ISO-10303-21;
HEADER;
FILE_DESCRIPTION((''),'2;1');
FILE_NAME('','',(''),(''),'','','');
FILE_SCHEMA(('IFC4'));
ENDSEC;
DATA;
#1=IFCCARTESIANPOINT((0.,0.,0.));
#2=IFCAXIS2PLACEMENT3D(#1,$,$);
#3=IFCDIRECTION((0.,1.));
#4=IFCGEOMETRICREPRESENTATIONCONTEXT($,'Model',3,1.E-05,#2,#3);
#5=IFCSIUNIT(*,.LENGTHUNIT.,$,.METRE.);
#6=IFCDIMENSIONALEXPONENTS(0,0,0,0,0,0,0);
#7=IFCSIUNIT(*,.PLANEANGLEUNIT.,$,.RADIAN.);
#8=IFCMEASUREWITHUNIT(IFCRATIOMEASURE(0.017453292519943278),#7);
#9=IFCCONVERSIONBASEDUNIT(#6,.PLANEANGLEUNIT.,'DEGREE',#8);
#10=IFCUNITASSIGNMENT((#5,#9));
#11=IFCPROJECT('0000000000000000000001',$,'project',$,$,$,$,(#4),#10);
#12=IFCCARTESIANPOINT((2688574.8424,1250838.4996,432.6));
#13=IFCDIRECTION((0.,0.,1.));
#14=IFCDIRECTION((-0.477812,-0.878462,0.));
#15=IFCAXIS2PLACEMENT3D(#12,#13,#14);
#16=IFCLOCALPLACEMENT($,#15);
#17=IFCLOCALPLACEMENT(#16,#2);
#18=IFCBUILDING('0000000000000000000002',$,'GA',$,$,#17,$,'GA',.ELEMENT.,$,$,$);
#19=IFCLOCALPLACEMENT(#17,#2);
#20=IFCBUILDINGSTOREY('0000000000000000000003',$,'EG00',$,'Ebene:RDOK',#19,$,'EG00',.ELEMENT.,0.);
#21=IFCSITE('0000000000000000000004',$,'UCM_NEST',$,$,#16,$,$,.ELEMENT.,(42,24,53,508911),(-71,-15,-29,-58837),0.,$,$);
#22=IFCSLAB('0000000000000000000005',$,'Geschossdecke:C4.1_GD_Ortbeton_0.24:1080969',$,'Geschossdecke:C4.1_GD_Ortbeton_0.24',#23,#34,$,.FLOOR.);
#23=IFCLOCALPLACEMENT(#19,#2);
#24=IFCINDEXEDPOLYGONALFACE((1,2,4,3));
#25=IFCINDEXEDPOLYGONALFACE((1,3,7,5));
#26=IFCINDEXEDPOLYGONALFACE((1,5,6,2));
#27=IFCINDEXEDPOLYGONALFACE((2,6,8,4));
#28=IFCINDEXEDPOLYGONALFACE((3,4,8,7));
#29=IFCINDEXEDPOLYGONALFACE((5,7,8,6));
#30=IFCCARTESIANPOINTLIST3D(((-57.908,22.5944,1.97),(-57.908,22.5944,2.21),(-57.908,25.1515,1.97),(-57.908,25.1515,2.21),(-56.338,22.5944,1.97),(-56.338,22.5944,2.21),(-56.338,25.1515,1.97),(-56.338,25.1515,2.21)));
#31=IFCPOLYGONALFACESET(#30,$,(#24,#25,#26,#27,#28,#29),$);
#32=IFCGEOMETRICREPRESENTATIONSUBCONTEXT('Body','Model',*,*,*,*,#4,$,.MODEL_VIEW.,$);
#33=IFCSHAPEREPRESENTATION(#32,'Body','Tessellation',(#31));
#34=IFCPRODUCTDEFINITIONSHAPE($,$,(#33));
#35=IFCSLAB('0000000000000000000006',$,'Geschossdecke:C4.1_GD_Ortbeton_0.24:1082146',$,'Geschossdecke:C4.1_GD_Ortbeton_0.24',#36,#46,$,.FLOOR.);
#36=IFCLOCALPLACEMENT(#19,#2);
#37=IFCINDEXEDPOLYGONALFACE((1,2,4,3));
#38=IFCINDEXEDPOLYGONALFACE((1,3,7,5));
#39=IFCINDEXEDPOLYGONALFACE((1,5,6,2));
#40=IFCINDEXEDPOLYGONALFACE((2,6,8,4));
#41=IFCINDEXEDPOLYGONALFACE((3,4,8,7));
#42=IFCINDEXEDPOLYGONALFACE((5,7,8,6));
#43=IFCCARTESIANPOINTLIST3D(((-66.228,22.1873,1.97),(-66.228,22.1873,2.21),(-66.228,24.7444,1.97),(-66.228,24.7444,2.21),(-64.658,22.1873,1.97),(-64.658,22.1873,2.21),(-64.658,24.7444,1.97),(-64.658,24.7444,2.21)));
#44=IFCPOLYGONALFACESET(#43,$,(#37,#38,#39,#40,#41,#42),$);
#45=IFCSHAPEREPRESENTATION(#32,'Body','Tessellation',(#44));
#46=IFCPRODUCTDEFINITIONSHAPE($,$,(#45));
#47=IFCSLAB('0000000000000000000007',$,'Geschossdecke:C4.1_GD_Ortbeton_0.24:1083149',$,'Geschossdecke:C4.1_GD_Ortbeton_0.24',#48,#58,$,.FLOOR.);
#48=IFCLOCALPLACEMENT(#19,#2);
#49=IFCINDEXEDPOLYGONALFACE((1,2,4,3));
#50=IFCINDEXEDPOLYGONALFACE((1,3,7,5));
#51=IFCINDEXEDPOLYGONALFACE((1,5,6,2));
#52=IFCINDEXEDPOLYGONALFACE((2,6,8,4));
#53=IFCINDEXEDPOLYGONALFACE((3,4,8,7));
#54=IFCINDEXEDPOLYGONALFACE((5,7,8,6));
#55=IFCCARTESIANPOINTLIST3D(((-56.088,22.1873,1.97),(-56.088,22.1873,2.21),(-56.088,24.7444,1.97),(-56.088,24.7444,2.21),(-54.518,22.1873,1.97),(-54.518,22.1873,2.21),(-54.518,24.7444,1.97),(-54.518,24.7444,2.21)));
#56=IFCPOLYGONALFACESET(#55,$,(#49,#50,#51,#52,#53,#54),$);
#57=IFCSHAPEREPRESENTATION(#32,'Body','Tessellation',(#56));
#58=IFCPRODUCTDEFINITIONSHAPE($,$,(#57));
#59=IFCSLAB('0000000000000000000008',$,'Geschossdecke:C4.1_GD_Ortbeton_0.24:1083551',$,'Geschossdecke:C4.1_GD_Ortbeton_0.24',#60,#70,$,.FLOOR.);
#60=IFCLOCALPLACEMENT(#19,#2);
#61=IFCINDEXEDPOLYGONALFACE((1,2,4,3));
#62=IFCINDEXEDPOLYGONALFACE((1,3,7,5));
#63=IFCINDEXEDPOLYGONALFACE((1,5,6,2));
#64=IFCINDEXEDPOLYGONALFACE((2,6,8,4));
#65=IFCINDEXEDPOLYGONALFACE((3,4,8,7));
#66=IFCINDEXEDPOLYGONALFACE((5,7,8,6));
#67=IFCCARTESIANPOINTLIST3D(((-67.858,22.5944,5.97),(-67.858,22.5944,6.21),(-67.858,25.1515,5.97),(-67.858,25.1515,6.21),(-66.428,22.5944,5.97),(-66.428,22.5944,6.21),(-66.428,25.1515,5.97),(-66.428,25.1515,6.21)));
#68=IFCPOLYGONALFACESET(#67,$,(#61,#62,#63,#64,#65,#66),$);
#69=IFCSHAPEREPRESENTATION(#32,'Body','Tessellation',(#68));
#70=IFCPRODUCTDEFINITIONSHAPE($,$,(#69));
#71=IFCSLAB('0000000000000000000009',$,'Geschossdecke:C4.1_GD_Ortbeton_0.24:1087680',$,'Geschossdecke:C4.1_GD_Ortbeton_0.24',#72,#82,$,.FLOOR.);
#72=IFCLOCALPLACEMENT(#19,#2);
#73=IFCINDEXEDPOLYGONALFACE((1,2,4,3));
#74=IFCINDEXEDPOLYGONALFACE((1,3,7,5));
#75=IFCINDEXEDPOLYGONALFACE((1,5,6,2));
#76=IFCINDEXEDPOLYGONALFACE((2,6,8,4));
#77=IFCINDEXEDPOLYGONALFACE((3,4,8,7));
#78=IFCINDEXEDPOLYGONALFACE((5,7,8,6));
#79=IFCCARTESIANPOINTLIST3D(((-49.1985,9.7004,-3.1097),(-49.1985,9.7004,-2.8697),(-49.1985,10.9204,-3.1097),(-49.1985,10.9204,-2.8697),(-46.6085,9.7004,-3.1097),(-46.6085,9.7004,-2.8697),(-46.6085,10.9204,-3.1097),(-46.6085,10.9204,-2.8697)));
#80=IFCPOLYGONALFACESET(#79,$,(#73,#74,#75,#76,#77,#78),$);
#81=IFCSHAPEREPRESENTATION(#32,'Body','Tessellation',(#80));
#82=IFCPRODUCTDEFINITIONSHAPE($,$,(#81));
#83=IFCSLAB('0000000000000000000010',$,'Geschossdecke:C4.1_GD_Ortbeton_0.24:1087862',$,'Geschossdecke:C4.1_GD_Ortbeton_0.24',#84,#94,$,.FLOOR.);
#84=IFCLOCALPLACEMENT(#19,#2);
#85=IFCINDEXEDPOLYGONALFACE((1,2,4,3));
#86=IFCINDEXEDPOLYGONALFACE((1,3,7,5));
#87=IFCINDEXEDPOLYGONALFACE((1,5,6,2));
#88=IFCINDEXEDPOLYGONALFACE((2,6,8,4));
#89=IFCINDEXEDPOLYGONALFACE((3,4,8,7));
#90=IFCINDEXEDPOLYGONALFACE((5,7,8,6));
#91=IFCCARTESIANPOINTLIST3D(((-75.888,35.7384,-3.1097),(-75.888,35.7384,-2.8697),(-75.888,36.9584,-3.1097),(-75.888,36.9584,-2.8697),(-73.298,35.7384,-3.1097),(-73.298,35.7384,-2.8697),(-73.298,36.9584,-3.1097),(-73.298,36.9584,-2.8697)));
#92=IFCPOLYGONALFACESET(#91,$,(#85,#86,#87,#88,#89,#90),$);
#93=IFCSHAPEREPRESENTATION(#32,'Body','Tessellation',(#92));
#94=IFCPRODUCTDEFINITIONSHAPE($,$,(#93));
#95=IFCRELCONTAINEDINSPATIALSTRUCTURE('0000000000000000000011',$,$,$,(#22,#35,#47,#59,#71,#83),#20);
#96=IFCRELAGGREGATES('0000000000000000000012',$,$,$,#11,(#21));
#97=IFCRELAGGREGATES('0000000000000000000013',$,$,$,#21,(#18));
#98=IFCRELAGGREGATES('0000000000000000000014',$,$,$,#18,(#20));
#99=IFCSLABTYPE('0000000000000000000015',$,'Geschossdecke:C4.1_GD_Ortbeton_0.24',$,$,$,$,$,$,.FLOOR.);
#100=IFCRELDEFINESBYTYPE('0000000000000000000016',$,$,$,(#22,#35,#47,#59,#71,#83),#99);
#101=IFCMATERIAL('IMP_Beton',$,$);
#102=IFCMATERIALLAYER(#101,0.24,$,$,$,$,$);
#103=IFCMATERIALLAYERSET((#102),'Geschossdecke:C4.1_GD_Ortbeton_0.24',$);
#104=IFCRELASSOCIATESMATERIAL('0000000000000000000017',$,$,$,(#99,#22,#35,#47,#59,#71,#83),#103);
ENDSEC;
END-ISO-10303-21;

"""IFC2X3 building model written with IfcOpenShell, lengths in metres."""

from ifc_helpers import new_model, entity, si_unit, converted_unit, direction, frame, frame_2d, origin, place, context, subcontext, project, spatial, rectangle, extrude, material, layer, layer_set, layer_usage, type_object, element, save


model = new_model("IFC2X3")

# Units and contexts
model_context = context("Model", 3, precision=1e-05, world=origin(), true_north=direction((0.0, 1.0)))
body_context = subcontext(model_context, "Body", "Model", "MODEL_VIEW")
ifc_project = project(units=[si_unit("LENGTHUNIT", "METRE"), converted_unit("PLANEANGLEUNIT", "DEGREE", entity("IfcRatioMeasure", 0.017453292519943278), si_unit("PLANEANGLEUNIT", "RADIAN"), dimensions=[0, 0, 0, 0, 0, 0, 0])], contexts=[model_context])

# Site, building, storey
site_placement = place(None, frame((2688574.8424, 1250838.4996, 432.6), z_axis=(0.0, 0.0, 1.0), x_axis=(-0.477812, -0.878462, 0.0)))
site = spatial("IfcSite", under=ifc_project, at=site_placement, Name="UCM_NEST", CompositionType="ELEMENT", RefLatitude=(42, 24, 53, 508911), RefLongitude=(-71, -15, -29, -58837), RefElevation=0.0)
building_placement = place(site_placement, origin())
building = spatial("IfcBuilding", under=site, at=building_placement, Name="GA", LongName="GA", CompositionType="ELEMENT")
storey_placement = place(building_placement, origin())
storey = spatial("IfcBuildingStorey", under=building, at=storey_placement, Name="EG00", ObjectType="Ebene:RDOK", LongName="EG00", CompositionType="ELEMENT", Elevation=0.0)

# Shared definitions
ifc_material_1 = material(Name="IMP_Beton")

# Slabs
ifc_layer_1 = layer(ifc_material_1, 0.24)
ifc_layer_set_1 = layer_set([ifc_layer_1], Name="Geschossdecke:C4.1_GD_Ortbeton_0.24")
ifc_layer_usage_1 = layer_usage(ifc_layer_set_1, "AXIS3", "POSITIVE", 0.0)
slab_type_1 = type_object("IfcSlabType", Name="Geschossdecke:C4.1_GD_Ortbeton_0.24", PredefinedType="FLOOR", material=ifc_layer_set_1)
slab_1_placement = place(storey_placement, origin())
element("IfcSlab", 1, at=slab_1_placement, inside=storey, type_object=slab_type_1, material=ifc_layer_usage_1, Name="Geschossdecke:C4.1_GD_Ortbeton_0.24:1080969", ObjectType="Geschossdecke:C4.1_GD_Ortbeton_0.24", PredefinedType="FLOOR", context=body_context, shape_type="SweptSolid", body=[
    extrude(rectangle(XDim=2.5571, YDim=1.57, at=frame_2d((0.0, 0.0), x_axis=(1.0, 0.0))), frame((-57.123, 23.873, 2.21), z_axis=(0.0, 0.0, -1.0), x_axis=(0.0, 1.0, 0.0)), (0.0, 0.0, 1.0), 0.24),
])
slab_2_placement = place(storey_placement, origin())
element("IfcSlab", 2, at=slab_2_placement, inside=storey, type_object=slab_type_1, material=ifc_layer_usage_1, Name="Geschossdecke:C4.1_GD_Ortbeton_0.24:1082146", ObjectType="Geschossdecke:C4.1_GD_Ortbeton_0.24", PredefinedType="FLOOR", context=body_context, shape_type="SweptSolid", body=[
    extrude(rectangle(XDim=2.5571, YDim=1.57, at=frame_2d((0.0, 0.0), x_axis=(1.0, 0.0))), frame((-65.443, 23.4659, 2.21), z_axis=(0.0, 0.0, -1.0), x_axis=(0.0, 1.0, 0.0)), (0.0, 0.0, 1.0), 0.24),
])
slab_3_placement = place(storey_placement, origin())
element("IfcSlab", 3, at=slab_3_placement, inside=storey, type_object=slab_type_1, material=ifc_layer_usage_1, Name="Geschossdecke:C4.1_GD_Ortbeton_0.24:1083149", ObjectType="Geschossdecke:C4.1_GD_Ortbeton_0.24", PredefinedType="FLOOR", context=body_context, shape_type="SweptSolid", body=[
    extrude(rectangle(XDim=2.5571, YDim=1.57, at=frame_2d((0.0, 0.0), x_axis=(1.0, 0.0))), frame((-55.303, 23.4659, 2.21), z_axis=(0.0, 0.0, -1.0), x_axis=(0.0, 1.0, 0.0)), (0.0, 0.0, 1.0), 0.24),
])
slab_4_placement = place(storey_placement, origin())
element("IfcSlab", 4, at=slab_4_placement, inside=storey, type_object=slab_type_1, material=ifc_layer_usage_1, Name="Geschossdecke:C4.1_GD_Ortbeton_0.24:1083551", ObjectType="Geschossdecke:C4.1_GD_Ortbeton_0.24", PredefinedType="FLOOR", context=body_context, shape_type="SweptSolid", body=[
    extrude(rectangle(XDim=2.5571, YDim=1.43, at=frame_2d((0.0, 0.0), x_axis=(1.0, 0.0))), frame((-67.143, 23.873, 6.21), z_axis=(0.0, 0.0, -1.0), x_axis=(0.0, 1.0, 0.0)), (0.0, 0.0, 1.0), 0.24),
])
slab_5_placement = place(storey_placement, origin())
element("IfcSlab", 5, at=slab_5_placement, inside=storey, type_object=slab_type_1, material=ifc_layer_usage_1, Name="Geschossdecke:C4.1_GD_Ortbeton_0.24:1087680", ObjectType="Geschossdecke:C4.1_GD_Ortbeton_0.24", PredefinedType="FLOOR", context=body_context, shape_type="SweptSolid", body=[
    extrude(rectangle(XDim=1.22, YDim=2.59, at=frame_2d((0.0, 0.0), x_axis=(1.0, 0.0))), frame((-47.9035, 10.3104, -2.8697), z_axis=(0.0, 0.0, -1.0), x_axis=(0.0, 1.0, 0.0)), (0.0, 0.0, 1.0), 0.24),
])
slab_6_placement = place(storey_placement, origin())
element("IfcSlab", 6, at=slab_6_placement, inside=storey, type_object=slab_type_1, material=ifc_layer_usage_1, Name="Geschossdecke:C4.1_GD_Ortbeton_0.24:1087862", ObjectType="Geschossdecke:C4.1_GD_Ortbeton_0.24", PredefinedType="FLOOR", context=body_context, shape_type="SweptSolid", body=[
    extrude(rectangle(XDim=1.22, YDim=2.59, at=frame_2d((0.0, 0.0), x_axis=(1.0, 0.0))), frame((-74.593, 36.3484, -2.8697), z_axis=(0.0, 0.0, -1.0), x_axis=(0.0, 1.0, 0.0)), (0.0, 0.0, 1.0), 0.24),
])

save(model, "model.ifc")
